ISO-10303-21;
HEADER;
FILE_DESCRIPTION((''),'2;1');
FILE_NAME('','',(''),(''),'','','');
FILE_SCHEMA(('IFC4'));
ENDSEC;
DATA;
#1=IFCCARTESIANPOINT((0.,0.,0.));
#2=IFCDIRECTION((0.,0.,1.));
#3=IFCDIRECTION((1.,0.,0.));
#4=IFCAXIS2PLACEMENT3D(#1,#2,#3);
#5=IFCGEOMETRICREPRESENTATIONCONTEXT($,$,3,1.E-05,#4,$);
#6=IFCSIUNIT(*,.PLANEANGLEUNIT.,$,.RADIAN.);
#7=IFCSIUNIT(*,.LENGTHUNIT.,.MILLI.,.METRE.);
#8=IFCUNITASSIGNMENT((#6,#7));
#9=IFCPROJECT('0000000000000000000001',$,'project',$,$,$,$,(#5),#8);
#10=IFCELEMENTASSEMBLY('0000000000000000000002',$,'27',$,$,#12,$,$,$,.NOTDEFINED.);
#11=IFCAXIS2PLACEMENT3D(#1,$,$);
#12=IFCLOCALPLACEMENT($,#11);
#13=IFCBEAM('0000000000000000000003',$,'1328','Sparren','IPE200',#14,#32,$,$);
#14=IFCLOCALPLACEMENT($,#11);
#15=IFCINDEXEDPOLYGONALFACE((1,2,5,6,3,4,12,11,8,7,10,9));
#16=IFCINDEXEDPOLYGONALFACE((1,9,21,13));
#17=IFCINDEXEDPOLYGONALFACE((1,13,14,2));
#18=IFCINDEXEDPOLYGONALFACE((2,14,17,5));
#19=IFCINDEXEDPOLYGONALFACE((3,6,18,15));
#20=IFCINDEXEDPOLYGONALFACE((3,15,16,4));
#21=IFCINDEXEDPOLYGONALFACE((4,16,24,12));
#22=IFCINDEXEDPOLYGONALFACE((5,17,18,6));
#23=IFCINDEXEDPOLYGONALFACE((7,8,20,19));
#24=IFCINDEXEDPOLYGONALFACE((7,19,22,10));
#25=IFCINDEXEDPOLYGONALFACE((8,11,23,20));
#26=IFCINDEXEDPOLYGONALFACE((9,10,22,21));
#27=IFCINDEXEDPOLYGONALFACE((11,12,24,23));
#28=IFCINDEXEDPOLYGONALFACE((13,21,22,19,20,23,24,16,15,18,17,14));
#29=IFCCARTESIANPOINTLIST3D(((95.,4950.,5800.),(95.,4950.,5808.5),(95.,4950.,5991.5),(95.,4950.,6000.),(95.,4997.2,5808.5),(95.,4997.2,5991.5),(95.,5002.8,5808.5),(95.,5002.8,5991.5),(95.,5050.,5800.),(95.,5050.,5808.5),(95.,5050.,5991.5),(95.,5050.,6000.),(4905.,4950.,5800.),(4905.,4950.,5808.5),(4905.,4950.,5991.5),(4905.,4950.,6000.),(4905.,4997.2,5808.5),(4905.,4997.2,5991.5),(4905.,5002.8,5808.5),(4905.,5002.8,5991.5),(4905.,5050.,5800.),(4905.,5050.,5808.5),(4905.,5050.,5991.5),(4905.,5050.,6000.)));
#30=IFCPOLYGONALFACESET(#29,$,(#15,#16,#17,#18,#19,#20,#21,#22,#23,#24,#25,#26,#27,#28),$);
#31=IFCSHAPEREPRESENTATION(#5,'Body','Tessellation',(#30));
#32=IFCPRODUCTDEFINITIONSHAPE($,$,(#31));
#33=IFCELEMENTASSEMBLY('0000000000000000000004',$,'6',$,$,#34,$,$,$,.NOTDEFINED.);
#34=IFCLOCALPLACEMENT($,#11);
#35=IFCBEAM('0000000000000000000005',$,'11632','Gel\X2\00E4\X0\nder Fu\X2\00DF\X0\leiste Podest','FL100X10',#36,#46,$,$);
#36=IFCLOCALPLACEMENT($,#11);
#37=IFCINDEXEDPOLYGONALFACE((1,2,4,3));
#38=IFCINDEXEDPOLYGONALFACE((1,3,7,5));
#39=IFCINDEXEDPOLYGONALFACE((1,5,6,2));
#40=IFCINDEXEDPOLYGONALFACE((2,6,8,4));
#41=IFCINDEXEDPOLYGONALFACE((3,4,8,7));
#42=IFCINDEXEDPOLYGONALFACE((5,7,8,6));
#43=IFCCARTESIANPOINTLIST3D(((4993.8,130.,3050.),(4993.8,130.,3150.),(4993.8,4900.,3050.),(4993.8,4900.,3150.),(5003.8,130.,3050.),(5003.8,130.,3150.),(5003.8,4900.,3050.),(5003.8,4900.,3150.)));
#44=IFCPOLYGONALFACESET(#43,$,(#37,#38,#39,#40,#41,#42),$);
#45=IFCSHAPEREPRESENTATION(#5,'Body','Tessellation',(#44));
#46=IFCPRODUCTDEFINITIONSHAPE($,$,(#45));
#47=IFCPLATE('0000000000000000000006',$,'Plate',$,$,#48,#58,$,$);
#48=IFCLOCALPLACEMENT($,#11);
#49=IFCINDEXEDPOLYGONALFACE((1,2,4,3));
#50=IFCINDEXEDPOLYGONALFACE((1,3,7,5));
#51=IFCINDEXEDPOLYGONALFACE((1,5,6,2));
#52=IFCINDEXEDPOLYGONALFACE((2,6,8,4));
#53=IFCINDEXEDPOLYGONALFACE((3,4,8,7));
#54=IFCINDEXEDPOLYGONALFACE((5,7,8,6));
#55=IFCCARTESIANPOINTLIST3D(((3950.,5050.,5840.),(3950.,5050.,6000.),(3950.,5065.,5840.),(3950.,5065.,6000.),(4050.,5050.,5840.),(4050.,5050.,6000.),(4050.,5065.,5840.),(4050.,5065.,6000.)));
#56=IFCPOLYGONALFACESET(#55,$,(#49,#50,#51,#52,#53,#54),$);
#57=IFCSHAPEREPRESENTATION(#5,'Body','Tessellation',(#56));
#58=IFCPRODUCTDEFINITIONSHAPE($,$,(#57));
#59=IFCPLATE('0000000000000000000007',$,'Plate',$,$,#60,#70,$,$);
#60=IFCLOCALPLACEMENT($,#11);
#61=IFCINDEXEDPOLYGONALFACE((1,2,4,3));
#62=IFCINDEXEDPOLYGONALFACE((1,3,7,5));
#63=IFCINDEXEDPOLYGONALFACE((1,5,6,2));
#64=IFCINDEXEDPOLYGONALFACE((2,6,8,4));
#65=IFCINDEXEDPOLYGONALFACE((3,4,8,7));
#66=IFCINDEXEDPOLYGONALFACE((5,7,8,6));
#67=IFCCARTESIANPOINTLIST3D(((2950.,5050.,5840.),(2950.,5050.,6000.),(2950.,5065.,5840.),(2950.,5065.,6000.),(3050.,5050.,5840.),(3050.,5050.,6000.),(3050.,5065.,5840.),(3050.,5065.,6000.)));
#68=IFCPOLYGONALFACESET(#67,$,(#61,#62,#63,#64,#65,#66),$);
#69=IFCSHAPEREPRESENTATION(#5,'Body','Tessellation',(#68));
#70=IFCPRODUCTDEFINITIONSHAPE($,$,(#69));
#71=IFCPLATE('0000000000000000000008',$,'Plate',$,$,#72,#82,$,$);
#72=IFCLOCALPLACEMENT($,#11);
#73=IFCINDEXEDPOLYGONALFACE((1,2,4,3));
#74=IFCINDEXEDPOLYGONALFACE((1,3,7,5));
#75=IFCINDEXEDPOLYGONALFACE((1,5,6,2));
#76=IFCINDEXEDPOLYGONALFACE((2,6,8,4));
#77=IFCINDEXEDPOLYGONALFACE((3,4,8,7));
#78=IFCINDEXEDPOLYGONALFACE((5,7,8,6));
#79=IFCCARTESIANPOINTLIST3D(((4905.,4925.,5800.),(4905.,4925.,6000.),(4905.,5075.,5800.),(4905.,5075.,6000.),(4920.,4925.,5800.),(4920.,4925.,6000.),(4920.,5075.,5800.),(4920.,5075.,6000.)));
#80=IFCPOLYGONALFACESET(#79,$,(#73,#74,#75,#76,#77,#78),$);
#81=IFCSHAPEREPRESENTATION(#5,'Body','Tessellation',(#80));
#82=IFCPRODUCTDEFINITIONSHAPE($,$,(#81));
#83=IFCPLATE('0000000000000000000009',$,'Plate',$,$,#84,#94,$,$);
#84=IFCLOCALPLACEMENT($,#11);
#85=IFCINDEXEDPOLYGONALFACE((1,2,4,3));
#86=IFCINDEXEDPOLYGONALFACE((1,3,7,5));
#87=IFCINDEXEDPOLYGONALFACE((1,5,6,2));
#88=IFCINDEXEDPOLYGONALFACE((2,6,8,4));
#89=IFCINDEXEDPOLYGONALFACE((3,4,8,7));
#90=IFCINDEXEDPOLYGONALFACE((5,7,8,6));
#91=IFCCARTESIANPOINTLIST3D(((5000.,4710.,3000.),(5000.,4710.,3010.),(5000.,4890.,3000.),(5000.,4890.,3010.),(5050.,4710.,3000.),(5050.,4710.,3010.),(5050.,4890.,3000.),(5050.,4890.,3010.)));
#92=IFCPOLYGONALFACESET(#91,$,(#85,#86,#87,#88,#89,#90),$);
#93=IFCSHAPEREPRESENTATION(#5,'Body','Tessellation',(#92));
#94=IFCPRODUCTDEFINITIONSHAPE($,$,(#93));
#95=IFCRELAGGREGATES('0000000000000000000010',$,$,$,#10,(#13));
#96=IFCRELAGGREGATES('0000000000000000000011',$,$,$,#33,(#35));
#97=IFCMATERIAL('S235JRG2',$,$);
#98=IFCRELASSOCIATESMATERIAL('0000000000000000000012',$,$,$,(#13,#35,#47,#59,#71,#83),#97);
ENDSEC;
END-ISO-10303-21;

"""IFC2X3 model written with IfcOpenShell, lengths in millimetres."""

from ifc_helpers import new_model, si_unit, frame, origin_with_axes, place, context, project, polyline, outline, extrude, clip, halfspace, material, element, aggregate, save


model = new_model("IFC2X3")

# Units and contexts
context_of_model = context(None, 3, precision=1e-05, world=origin_with_axes())
ifc_project = project(units=[si_unit("PLANEANGLEUNIT", "RADIAN"), si_unit("LENGTHUNIT", "METRE", prefix="MILLI")], contexts=[context_of_model])

# Element assemblies, beams
assembly_1_placement = place(None, frame((5000.0, 5000.0, 6000.0), z_axis=(0.0, 0.0, 1.0), x_axis=(-1.0, 0.0, 0.0)))
assembly_1 = element("IfcElementAssembly", 1, at=assembly_1_placement, Name="27", PredefinedType="NOTDEFINED")
ifc_material = material(Name="S235JRG2")
placement_1 = place(None, frame((5000.0, 5000.0, 5900.0), z_axis=(0.0, 0.0, 1.0), x_axis=(-1.0, 0.0, 0.0)))
beam_1_placement = place(placement_1, origin_with_axes())
beam_1 = element("IfcBeam", 2, at=beam_1_placement, material=ifc_material, Name="1328", Description="Sparren", ObjectType="IPE200", context=context_of_model, shape_type="Clipping", body=[
    clip(clip(extrude(outline(polyline([(50.0, -100.0), (50.0, -91.5), (2.8, -91.5), (2.8, 91.5), (50.0, 91.5), (50.0, 100.0), (-50.0, 100.0), (-50.0, 91.5), (-2.8, 91.5), (-2.8, -91.5), (-50.0, -91.5), (-50.0, -100.0), (50.0, -100.0), (50.0, -100.0)])), frame((0.0, 0.0, 0.0), z_axis=(1.0, 0.0, 0.0), x_axis=(0.0, 1.0, 0.0)), (0.0, 0.0, 1.0), 5000.0), halfspace(frame((4905.0, 0.0, 100.0), z_axis=(1.0, 0.0, 0.0), x_axis=(0.0, 0.0, 1.0)), False)), halfspace(frame((95.0, 0.0, 100.0), z_axis=(-1.0, 0.0, 0.0), x_axis=(0.0, 0.0, -1.0)), False)),
])
aggregate(assembly_1, [beam_1])
assembly_2_placement = place(None, frame((1.2, 5130.0, 6100.0), z_axis=(0.0, 0.0, 1.0), x_axis=(0.0, 1.0, 0.0)))
assembly_2 = element("IfcElementAssembly", 3, at=assembly_2_placement, Name="6", PredefinedType="NOTDEFINED")
placement_2 = place(None, frame((4998.8, 4900.0, 3100.0), z_axis=(0.0, 0.0, 1.0), x_axis=(0.0, -1.0, 0.0)))
beam_2_placement = place(placement_2, origin_with_axes())
beam_2 = element("IfcBeam", 4, at=beam_2_placement, material=ifc_material, Name="11632", Description="Geländer Fußleiste Podest", ObjectType="FL100X10", context=context_of_model, shape_type="SweptSolid", body=[
    extrude(outline(polyline([(5.0, -50.0), (5.0, 50.0), (-5.0, 50.0), (-5.0, -50.0), (5.0, -50.0), (5.0, -50.0)])), frame((0.0, 0.0, 0.0), z_axis=(1.0, 0.0, 0.0), x_axis=(0.0, 1.0, 0.0)), (0.0, 0.0, 1.0), 4770.0),
])
aggregate(assembly_2, [beam_2])

# Plates
placement_3 = place(None, origin_with_axes())
plate_1_placement = place(placement_3, frame((4050.0, 5065.0, 5840.0), z_axis=(-1.0, 0.0, 0.0), x_axis=(0.0, -1.0, 0.0)))
element("IfcPlate", 5, at=plate_1_placement, material=ifc_material, Name="Plate", context=context_of_model, shape_type="SweptSolid", body=[
    extrude(outline(polyline([(0.0, 0.0), (160.0, 0.0), (160.0, 100.0), (0.0, 100.0), (0.0, 0.0)])), frame((0.0, 0.0, 0.0), z_axis=(1.0, 0.0, 0.0), x_axis=(0.0, 1.0, 0.0)), (0.0, 0.0, 1.0), 15.0),
])
placement_4 = place(None, origin_with_axes())
plate_2_placement = place(placement_4, frame((3050.0, 5065.0, 5840.0), z_axis=(-1.0, 0.0, 0.0), x_axis=(0.0, -1.0, 0.0)))
element("IfcPlate", 6, at=plate_2_placement, material=ifc_material, Name="Plate", context=context_of_model, shape_type="SweptSolid", body=[
    extrude(outline(polyline([(0.0, 0.0), (160.0, 0.0), (160.0, 100.0), (0.0, 100.0), (0.0, 0.0)])), frame((0.0, 0.0, 0.0), z_axis=(1.0, 0.0, 0.0), x_axis=(0.0, 1.0, 0.0)), (0.0, 0.0, 1.0), 15.0),
])
placement_5 = place(None, origin_with_axes())
plate_3_placement = place(placement_5, frame((4905.0, 5075.0, 5800.0), z_axis=(0.0, -1.0, 0.0), x_axis=(1.0, 0.0, 0.0)))
element("IfcPlate", 7, at=plate_3_placement, material=ifc_material, Name="Plate", context=context_of_model, shape_type="SweptSolid", body=[
    extrude(outline(polyline([(0.0, 0.0), (200.0, 0.0), (200.0, 150.0), (0.0, 150.0), (0.0, 0.0)])), frame((0.0, 0.0, 0.0), z_axis=(1.0, 0.0, 0.0), x_axis=(0.0, 1.0, 0.0)), (0.0, 0.0, 1.0), 15.0),
])
placement_6 = place(None, origin_with_axes())
plate_4_placement = place(placement_6, frame((5000.0, 4710.0, 3010.0), z_axis=(1.0, 0.0, 0.0), x_axis=(0.0, 0.0, -1.0)))
element("IfcPlate", 8, at=plate_4_placement, material=ifc_material, Name="Plate", context=context_of_model, shape_type="SweptSolid", body=[
    extrude(outline(polyline([(0.0, 0.0), (180.0, 0.0), (180.0, 50.0), (0.0, 50.0), (0.0, 0.0)])), frame((0.0, 0.0, 0.0), z_axis=(1.0, 0.0, 0.0), x_axis=(0.0, 1.0, 0.0)), (0.0, 0.0, 1.0), 10.0),
])

save(model, "model.ifc")
